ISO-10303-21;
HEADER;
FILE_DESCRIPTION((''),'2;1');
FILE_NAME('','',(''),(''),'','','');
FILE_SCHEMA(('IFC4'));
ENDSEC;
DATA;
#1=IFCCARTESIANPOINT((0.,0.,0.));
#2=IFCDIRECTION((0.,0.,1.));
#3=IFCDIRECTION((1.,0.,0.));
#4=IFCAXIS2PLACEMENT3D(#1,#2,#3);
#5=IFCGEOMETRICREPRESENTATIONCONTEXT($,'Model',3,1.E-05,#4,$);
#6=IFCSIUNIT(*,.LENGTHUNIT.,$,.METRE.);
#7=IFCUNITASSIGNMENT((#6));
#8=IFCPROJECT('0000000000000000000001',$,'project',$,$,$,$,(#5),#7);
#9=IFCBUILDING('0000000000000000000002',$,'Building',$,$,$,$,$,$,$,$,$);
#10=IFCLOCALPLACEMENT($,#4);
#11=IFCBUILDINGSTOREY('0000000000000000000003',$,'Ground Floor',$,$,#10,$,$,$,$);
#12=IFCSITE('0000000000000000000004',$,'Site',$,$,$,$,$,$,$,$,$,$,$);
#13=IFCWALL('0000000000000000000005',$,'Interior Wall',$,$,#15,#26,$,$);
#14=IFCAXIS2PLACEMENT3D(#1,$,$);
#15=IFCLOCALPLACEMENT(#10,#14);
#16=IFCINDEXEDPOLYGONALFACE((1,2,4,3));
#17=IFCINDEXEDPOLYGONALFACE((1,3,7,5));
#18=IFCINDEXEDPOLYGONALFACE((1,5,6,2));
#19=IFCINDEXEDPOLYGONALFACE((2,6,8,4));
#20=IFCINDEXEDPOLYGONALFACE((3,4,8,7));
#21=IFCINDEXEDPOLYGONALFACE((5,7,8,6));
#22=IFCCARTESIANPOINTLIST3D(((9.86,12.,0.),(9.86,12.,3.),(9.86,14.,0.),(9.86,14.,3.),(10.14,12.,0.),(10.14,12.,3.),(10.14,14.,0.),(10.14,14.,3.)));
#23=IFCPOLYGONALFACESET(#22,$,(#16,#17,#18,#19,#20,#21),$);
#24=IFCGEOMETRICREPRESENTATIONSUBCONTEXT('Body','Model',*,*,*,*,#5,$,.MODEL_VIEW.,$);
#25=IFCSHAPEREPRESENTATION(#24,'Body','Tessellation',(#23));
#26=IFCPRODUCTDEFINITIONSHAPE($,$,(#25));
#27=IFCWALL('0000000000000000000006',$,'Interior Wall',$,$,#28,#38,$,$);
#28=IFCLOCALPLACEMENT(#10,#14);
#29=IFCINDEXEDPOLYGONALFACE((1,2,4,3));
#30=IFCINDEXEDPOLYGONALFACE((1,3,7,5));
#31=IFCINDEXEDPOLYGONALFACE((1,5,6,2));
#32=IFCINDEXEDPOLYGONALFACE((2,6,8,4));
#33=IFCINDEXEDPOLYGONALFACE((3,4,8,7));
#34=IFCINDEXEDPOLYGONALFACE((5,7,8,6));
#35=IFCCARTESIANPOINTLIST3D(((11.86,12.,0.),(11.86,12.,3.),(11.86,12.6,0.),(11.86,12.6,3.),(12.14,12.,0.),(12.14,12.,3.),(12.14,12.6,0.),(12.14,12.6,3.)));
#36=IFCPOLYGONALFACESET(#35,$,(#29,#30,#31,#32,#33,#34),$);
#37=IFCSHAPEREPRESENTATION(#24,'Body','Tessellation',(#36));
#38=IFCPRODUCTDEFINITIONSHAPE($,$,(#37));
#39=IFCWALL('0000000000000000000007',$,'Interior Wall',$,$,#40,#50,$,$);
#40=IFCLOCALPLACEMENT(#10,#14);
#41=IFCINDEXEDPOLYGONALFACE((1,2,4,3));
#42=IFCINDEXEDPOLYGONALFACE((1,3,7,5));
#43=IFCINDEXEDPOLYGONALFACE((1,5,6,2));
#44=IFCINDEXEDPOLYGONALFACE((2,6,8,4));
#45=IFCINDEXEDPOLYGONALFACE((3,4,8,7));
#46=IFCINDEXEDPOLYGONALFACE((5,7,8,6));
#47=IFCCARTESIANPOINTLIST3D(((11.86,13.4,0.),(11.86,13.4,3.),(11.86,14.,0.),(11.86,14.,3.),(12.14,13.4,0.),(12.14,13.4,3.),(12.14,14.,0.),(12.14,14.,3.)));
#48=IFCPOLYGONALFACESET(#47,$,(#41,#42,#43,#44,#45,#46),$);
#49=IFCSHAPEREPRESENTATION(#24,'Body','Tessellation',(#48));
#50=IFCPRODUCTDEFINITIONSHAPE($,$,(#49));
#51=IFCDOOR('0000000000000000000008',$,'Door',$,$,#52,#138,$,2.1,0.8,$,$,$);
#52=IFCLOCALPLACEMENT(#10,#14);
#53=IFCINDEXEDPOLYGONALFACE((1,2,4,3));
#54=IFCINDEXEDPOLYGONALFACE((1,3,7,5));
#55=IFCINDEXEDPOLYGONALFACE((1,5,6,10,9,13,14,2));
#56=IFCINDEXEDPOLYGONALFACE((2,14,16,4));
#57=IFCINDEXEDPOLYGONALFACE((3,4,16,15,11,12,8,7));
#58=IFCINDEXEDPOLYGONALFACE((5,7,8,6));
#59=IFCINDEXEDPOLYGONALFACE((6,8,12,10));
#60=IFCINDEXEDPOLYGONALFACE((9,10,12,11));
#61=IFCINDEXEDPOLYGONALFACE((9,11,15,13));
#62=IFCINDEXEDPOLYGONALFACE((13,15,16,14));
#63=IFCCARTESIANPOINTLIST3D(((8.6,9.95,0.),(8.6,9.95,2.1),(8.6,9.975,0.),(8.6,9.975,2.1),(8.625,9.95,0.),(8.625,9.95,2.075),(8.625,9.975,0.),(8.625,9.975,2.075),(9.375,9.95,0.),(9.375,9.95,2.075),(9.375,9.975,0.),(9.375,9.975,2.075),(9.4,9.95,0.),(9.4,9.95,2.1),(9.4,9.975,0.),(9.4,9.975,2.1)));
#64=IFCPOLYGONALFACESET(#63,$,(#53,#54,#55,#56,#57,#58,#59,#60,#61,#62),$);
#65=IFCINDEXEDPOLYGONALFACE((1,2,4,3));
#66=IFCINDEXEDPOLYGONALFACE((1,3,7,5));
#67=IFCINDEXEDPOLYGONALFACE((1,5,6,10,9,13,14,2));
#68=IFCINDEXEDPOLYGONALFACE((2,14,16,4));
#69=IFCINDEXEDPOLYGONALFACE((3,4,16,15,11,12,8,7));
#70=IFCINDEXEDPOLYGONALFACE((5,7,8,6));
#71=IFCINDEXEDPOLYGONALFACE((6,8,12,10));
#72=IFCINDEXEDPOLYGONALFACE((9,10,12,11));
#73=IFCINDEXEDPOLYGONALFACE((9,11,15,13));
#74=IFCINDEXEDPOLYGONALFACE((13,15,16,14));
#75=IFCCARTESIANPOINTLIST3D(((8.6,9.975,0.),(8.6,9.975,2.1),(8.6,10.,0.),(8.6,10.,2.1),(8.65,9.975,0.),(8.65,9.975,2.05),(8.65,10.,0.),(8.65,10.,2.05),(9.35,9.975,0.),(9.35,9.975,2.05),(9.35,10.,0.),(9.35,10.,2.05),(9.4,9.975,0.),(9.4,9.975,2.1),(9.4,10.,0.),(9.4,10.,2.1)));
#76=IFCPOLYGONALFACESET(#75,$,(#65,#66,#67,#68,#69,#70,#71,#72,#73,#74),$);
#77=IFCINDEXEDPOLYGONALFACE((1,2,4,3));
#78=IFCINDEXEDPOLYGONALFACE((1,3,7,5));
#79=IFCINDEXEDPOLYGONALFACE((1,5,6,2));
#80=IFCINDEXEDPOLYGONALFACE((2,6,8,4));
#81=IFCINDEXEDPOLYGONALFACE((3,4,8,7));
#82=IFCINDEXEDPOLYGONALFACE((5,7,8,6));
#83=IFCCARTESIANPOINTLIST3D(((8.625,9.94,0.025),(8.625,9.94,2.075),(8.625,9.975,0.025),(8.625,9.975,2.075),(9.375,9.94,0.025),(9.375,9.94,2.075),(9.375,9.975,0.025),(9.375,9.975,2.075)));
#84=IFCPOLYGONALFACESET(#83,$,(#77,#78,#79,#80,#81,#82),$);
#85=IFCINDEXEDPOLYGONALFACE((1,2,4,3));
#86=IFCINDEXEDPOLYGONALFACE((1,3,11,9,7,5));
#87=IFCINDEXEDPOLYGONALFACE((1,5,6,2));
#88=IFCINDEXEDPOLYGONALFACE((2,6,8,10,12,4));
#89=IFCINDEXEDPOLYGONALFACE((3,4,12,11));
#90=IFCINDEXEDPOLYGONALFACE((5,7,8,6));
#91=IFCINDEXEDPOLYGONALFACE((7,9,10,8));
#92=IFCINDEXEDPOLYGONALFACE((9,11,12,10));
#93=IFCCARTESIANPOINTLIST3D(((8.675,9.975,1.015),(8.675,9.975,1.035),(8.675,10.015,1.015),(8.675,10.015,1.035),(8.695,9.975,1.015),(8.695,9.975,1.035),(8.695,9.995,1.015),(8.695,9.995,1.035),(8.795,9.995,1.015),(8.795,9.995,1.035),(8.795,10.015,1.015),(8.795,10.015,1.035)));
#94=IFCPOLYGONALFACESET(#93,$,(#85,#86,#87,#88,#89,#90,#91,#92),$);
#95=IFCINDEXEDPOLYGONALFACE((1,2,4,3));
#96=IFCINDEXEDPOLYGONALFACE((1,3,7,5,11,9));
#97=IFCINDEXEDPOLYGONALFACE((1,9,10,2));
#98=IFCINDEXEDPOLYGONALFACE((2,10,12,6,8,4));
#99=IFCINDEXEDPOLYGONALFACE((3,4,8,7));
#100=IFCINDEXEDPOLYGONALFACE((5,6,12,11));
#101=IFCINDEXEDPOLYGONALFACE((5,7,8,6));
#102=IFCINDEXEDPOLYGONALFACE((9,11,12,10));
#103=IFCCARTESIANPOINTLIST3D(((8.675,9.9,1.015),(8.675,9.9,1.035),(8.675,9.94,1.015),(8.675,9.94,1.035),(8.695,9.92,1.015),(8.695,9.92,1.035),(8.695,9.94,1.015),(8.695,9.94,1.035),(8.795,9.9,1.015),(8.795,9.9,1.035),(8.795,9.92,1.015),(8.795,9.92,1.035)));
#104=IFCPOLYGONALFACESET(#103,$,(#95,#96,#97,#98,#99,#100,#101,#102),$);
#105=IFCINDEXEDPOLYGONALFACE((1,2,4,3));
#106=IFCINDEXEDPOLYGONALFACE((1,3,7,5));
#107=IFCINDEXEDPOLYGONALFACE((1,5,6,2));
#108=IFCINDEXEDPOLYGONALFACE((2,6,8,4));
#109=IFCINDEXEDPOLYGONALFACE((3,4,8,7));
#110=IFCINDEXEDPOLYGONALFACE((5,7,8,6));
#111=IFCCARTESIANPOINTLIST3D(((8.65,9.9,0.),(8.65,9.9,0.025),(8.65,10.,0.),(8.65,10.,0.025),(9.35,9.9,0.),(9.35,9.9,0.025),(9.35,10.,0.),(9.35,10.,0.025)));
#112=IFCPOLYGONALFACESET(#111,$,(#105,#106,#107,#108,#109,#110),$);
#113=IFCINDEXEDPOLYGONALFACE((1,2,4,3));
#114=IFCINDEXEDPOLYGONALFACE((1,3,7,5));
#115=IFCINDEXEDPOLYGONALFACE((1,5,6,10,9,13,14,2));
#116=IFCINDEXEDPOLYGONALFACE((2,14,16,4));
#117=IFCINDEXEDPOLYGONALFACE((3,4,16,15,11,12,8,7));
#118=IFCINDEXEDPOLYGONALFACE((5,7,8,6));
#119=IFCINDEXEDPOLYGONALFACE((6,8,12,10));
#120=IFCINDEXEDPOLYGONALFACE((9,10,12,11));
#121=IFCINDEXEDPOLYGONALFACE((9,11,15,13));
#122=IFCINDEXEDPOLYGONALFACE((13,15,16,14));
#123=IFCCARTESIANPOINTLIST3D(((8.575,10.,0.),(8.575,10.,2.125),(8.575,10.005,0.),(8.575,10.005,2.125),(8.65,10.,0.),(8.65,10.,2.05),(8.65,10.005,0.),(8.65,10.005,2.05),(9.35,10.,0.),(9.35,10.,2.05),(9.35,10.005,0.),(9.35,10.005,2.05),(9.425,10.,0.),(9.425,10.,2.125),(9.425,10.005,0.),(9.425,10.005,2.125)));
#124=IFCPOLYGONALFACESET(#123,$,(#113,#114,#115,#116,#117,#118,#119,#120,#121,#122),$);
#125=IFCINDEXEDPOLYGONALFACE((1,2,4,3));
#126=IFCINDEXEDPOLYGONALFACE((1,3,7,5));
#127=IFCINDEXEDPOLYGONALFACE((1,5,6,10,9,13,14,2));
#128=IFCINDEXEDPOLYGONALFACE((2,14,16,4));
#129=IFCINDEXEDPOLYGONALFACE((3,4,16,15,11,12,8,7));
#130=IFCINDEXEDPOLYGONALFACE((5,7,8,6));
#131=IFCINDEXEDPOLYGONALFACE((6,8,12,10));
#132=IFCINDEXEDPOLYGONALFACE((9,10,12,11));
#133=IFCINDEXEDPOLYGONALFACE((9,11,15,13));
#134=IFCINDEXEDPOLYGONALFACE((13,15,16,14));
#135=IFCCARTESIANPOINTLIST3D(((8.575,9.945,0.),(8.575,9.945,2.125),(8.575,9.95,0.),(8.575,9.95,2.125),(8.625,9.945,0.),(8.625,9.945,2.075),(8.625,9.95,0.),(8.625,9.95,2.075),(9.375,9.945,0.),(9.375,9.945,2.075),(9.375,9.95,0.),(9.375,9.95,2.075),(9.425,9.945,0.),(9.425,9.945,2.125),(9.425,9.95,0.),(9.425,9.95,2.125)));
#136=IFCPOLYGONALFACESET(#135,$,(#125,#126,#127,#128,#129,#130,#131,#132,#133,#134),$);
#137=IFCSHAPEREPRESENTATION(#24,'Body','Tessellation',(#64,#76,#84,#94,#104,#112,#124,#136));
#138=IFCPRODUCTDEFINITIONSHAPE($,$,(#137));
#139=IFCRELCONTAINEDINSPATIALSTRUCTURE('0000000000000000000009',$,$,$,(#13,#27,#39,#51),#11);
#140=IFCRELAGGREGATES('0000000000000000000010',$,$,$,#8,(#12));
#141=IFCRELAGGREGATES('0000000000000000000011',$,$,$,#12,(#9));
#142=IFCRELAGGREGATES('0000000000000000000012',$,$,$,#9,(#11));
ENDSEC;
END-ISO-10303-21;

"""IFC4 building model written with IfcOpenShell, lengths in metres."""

from ifc_helpers import new_model, si_unit, frame, origin_with_axes, place, context, subcontext, project, spatial, line, indexed_curve, outline, extrude, element, save


model = new_model("IFC4")

# Units and contexts
model_context = context("Model", 3, precision=1e-05, world=origin_with_axes())
body_context = subcontext(model_context, "Body", "Model", "MODEL_VIEW")
ifc_project = project(units=[si_unit("LENGTHUNIT", "METRE")], contexts=[model_context])

# Site, building, storey
site = spatial("IfcSite", under=ifc_project, Name="Site")
building = spatial("IfcBuilding", under=site, Name="Building")
storey_placement = place(None, origin_with_axes())
storey = spatial("IfcBuildingStorey", under=building, at=storey_placement, Name="Ground Floor")

# Walls
wall_1_placement = place(storey_placement, frame((10.0, 12.0, 0.0), z_axis=(0.0, 0.0, 1.0), x_axis=(0.0, 1.0, 0.0)))
element("IfcWall", 1, at=wall_1_placement, inside=storey, Name="Interior Wall", context=body_context, shape_type="SweptSolid", body=[
    extrude(outline(indexed_curve([(0.0, 0.0), (0.0, 0.28), (2.0, 0.28), (2.0, 0.0), (0.0, 0.0)], self_intersect=False)), frame((0.0, -0.14, 0.0), z_axis=(0.0, 0.0, 1.0), x_axis=(1.0, 0.0, 0.0)), (0.0, 0.0, 1.0), 3.0),
])
for number, where, z_axis, x_axis, name in (
    (2, (12.0, 12.0, 0.0), (0.0, 0.0, 1.0), (0.0, 1.0, 0.0), "Interior Wall"),
    (3, (12.0, 13.4, 0.0), (0.0, 0.0, 1.0), (0.0, 1.0, 0.0), "Interior Wall"),
):
    element("IfcWall", number, at=place(storey_placement, frame(where, z_axis=z_axis, x_axis=x_axis)), inside=storey, Name=name, context=body_context, shape_type="SweptSolid", body=[
        extrude(outline(indexed_curve([(0.0, 0.0), (0.0, 0.28), (0.6, 0.28), (0.6, 0.0), (0.0, 0.0)], self_intersect=False)), frame((0.0, -0.14, 0.0), z_axis=(0.0, 0.0, 1.0), x_axis=(1.0, 0.0, 0.0)), (0.0, 0.0, 1.0), 3.0),
    ])

# Door
door_1_placement = place(storey_placement, frame((9.4, 10.0, 0.0), z_axis=(0.0, 0.0, 1.0), x_axis=(-1.0, 0.0, 0.0)))
element("IfcDoor", 4, at=door_1_placement, inside=storey, Name="Door", OverallHeight=2.1, OverallWidth=0.8, context=body_context, shape_type="SweptSolid", body=[
    extrude(outline(indexed_curve([(0.0, 0.0), (0.0, 2.1), (0.8, 2.1), (0.8, 0.0), (0.775, 0.0), (0.775, 2.075), (0.025, 2.075), (0.025, 0.0)], segments=[line(1, 2, 3, 4, 5, 6, 7, 8, 1)])), frame((0.0, 0.025, 0.0), z_axis=(0.0, -1.0, 0.0), x_axis=(1.0, 0.0, 0.0)), (0.0, 0.0, -1.0), 0.025),
    extrude(outline(indexed_curve([(0.0, 0.0), (0.0, 2.1), (0.8, 2.1), (0.8, 0.0), (0.75, 0.0), (0.75, 2.05), (0.05, 2.05), (0.05, 0.0)], segments=[line(1, 2, 3, 4, 5, 6, 7, 8, 1)])), frame((0.0, 0.0, 0.0), z_axis=(0.0, -1.0, 0.0), x_axis=(1.0, 0.0, 0.0)), (0.0, 0.0, -1.0), 0.025),
    extrude(outline(indexed_curve([(0.0, 0.0), (0.75, 0.0), (0.75, 0.035), (0.0, 0.035)], segments=[line(1, 2, 3, 4, 1)])), frame((0.025, 0.025, 0.025), z_axis=(0.0, 0.0, 1.0), x_axis=(1.0, 0.0, 0.0)), (0.0, 0.0, 1.0), 2.05),
    extrude(outline(indexed_curve([(0.0, 0.0), (0.0, -0.04), (-0.12, -0.04), (-0.12, -0.02), (-0.02, -0.02), (-0.02, 0.0)], segments=[line(1, 2, 3, 4, 5, 6, 1)])), frame((0.725, 0.025, 1.015), z_axis=(0.0, 0.0, 1.0), x_axis=(1.0, 0.0, 0.0)), (0.0, 0.0, 1.0), 0.02),
    extrude(outline(indexed_curve([(0.0, 0.0), (0.0, 0.04), (-0.12, 0.04), (-0.12, 0.02), (-0.02, 0.02), (-0.02, 0.0)], segments=[line(1, 2, 3, 4, 5, 6, 1)])), frame((0.725, 0.06, 1.015), z_axis=(0.0, 0.0, 1.0), x_axis=(1.0, 0.0, 0.0)), (0.0, 0.0, 1.0), 0.02),
    extrude(outline(indexed_curve([(0.0, 0.0), (0.7, 0.0), (0.7, 0.1), (0.0, 0.1)], segments=[line(1, 2, 3, 4, 1)])), frame((0.05, 0.0, 0.0), z_axis=(0.0, 0.0, 1.0), x_axis=(1.0, 0.0, 0.0)), (0.0, 0.0, 1.0), 0.025),
    extrude(outline(indexed_curve([(0.0, 0.0), (0.0, 2.125), (0.85, 2.125), (0.85, 0.0), (0.775, 0.0), (0.775, 2.05), (0.075, 2.05), (0.075, 0.0)], segments=[line(1, 2, 3, 4, 5, 6, 7, 8, 1)])), frame((-0.025, -0.005, 0.0), z_axis=(0.0, -1.0, 0.0), x_axis=(1.0, 0.0, 0.0)), (0.0, 0.0, -1.0), 0.005),
    extrude(outline(indexed_curve([(0.0, 0.0), (0.0, 2.125), (0.85, 2.125), (0.85, 0.0), (0.8, 0.0), (0.8, 2.075), (0.05, 2.075), (0.05, 0.0)], segments=[line(1, 2, 3, 4, 5, 6, 7, 8, 1)])), frame((-0.025, 0.05, 0.0), z_axis=(0.0, -1.0, 0.0), x_axis=(1.0, 0.0, 0.0)), (0.0, 0.0, -1.0), 0.005),
])

save(model, "model.ifc")
